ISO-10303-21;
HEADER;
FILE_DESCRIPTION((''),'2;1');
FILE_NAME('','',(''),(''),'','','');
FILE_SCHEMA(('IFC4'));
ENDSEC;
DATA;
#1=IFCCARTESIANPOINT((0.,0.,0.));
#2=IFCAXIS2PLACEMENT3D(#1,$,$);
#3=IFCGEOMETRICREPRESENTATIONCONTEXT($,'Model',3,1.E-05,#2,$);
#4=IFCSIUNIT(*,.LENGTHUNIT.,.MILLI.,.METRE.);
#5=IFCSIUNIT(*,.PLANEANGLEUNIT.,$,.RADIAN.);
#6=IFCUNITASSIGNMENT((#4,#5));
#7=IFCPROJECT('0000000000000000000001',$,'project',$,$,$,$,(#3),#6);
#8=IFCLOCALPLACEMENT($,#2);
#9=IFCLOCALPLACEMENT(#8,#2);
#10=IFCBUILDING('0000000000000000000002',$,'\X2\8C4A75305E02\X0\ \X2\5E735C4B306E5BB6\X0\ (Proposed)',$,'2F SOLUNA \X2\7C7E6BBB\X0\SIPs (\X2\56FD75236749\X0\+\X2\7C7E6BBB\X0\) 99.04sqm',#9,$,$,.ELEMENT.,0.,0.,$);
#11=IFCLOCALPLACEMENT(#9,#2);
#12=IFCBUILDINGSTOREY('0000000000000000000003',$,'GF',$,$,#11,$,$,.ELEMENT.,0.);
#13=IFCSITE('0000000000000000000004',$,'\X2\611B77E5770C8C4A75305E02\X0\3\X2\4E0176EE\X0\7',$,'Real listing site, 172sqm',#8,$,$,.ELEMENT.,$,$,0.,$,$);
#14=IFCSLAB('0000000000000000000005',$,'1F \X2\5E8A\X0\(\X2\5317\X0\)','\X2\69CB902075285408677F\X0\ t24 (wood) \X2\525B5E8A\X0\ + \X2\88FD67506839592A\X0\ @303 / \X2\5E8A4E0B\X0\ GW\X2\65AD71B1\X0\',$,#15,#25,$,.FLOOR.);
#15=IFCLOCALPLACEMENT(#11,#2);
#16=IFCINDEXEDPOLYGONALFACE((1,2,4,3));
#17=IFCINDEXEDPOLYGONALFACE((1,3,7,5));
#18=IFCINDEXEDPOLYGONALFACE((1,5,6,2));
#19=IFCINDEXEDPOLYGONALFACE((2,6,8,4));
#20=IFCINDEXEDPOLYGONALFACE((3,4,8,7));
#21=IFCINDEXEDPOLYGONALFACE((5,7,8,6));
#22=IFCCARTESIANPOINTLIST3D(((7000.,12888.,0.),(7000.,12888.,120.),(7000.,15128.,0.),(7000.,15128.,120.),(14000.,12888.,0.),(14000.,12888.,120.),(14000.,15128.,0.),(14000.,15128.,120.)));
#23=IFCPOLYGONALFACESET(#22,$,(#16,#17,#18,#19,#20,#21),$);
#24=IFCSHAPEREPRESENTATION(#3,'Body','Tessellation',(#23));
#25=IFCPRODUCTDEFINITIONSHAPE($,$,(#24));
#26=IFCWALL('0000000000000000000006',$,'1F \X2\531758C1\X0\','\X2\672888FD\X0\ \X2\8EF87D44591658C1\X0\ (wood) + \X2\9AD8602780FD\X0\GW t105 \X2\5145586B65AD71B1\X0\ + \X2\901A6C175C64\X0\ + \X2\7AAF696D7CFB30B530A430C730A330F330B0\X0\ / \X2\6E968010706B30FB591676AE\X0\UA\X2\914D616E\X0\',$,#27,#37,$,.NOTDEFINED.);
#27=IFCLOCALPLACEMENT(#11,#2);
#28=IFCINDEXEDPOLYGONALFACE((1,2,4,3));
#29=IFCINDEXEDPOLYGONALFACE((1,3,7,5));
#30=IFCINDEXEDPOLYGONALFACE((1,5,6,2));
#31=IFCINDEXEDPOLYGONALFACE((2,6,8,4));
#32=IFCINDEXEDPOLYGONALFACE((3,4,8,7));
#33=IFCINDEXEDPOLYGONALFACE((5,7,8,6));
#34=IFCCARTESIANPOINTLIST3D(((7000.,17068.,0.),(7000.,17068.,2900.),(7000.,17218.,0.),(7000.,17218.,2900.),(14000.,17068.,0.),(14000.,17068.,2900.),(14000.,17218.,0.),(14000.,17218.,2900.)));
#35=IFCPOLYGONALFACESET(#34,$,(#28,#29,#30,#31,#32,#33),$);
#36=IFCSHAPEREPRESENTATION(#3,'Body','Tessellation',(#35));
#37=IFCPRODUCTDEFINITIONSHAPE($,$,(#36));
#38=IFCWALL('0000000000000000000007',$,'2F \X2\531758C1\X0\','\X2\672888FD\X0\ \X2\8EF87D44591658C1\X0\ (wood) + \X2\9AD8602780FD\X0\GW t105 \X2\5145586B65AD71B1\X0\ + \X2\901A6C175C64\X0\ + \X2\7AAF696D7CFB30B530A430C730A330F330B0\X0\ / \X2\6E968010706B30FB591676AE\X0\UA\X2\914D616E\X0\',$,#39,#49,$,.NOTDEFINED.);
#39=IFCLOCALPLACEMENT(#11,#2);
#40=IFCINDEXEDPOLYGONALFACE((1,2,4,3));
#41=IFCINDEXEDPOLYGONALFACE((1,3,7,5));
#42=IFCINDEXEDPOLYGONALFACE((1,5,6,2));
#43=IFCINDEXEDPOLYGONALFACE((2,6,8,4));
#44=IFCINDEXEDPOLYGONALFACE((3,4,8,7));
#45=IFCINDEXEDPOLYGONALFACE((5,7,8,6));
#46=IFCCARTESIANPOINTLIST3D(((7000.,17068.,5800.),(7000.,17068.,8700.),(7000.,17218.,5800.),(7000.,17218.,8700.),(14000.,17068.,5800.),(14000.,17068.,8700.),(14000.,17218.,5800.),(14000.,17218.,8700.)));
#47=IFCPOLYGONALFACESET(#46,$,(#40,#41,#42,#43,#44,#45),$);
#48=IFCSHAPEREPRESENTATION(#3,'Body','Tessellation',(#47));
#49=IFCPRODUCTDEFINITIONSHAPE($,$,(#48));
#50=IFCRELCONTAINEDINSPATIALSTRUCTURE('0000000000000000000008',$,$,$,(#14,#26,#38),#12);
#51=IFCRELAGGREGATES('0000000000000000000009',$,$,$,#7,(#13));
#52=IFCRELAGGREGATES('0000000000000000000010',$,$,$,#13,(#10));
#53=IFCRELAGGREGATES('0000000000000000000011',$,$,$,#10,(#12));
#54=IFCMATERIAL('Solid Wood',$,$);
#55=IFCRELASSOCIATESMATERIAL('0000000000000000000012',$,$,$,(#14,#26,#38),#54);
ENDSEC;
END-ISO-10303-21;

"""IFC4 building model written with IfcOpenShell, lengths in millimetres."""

from ifc_helpers import new_model, si_unit, frame, frame_2d, origin, place, context, project, spatial, rectangle, extrude, material, element, save


model = new_model("IFC4")

# Units and contexts
model_context = context("Model", 3, precision=1e-05, world=origin())
ifc_project = project(units=[si_unit("LENGTHUNIT", "METRE", prefix="MILLI"), si_unit("PLANEANGLEUNIT", "RADIAN")], contexts=[model_context])

# Site, building, storey
site_placement = place(None, origin())
site = spatial("IfcSite", under=ifc_project, at=site_placement, Name="愛知県豊田市3丁目7", ObjectType="Real listing site, 172sqm", CompositionType="ELEMENT", RefElevation=0.0)
building_placement = place(site_placement, origin())
building = spatial("IfcBuilding", under=site, at=building_placement, Name="豊田市 平屋の家 (Proposed)", ObjectType="2F SOLUNA 籾殻SIPs (国産杉+籾殻) 99.04sqm", CompositionType="ELEMENT", ElevationOfRefHeight=0.0, ElevationOfTerrain=0.0)
storey_placement = place(building_placement, origin())
storey = spatial("IfcBuildingStorey", under=building, at=storey_placement, Name="GF", CompositionType="ELEMENT", Elevation=0.0)

# Slab
ifc_material_1 = material(Name="Solid Wood")
slab_1_placement = place(storey_placement, frame((3500.0, 6444.0, 0.0)))
element("IfcSlab", 1, at=slab_1_placement, inside=storey, material=ifc_material_1, Name="1F 床(北)", Description="構造用合板 t24 (wood) 剛床 + 製材根太 @303 / 床下 GW断熱", PredefinedType="FLOOR", context=model_context, shape_type="SweptSolid", body=[
    extrude(rectangle(XDim=7000.0, YDim=2240.0, at=frame_2d((3500.0, 1120.0))), frame((3500.0, 6444.0, 0.0)), (0.0, 0.0, 1.0), 120.0),
])

# Wall
wall_1_placement = place(storey_placement, frame((3500.0, 8534.0, 0.0)))
element("IfcWall", 2, at=wall_1_placement, inside=storey, material=ifc_material_1, Name="1F 北壁", Description="木製 軸組外壁 (wood) + 高性能GW t105 充填断熱 + 通気層 + 窯業系サイディング / 準耐火・外皮UA配慮", PredefinedType="NOTDEFINED", context=model_context, shape_type="SweptSolid", body=[
    extrude(rectangle(XDim=7000.0, YDim=150.0, at=frame_2d((3500.0, 75.0))), frame((3500.0, 8534.0, 0.0)), (0.0, 0.0, 1.0), 2900.0),
])

# Wall
wall_2_placement = place(storey_placement, frame((3500.0, 8534.0, 2900.0)))
element("IfcWall", 3, at=wall_2_placement, inside=storey, material=ifc_material_1, Name="2F 北壁", Description="木製 軸組外壁 (wood) + 高性能GW t105 充填断熱 + 通気層 + 窯業系サイディング / 準耐火・外皮UA配慮", PredefinedType="NOTDEFINED", context=model_context, shape_type="SweptSolid", body=[
    extrude(rectangle(XDim=7000.0, YDim=150.0, at=frame_2d((3500.0, 75.0))), frame((3500.0, 8534.0, 2900.0)), (0.0, 0.0, 1.0), 2900.0),
])

save(model, "model.ifc")
